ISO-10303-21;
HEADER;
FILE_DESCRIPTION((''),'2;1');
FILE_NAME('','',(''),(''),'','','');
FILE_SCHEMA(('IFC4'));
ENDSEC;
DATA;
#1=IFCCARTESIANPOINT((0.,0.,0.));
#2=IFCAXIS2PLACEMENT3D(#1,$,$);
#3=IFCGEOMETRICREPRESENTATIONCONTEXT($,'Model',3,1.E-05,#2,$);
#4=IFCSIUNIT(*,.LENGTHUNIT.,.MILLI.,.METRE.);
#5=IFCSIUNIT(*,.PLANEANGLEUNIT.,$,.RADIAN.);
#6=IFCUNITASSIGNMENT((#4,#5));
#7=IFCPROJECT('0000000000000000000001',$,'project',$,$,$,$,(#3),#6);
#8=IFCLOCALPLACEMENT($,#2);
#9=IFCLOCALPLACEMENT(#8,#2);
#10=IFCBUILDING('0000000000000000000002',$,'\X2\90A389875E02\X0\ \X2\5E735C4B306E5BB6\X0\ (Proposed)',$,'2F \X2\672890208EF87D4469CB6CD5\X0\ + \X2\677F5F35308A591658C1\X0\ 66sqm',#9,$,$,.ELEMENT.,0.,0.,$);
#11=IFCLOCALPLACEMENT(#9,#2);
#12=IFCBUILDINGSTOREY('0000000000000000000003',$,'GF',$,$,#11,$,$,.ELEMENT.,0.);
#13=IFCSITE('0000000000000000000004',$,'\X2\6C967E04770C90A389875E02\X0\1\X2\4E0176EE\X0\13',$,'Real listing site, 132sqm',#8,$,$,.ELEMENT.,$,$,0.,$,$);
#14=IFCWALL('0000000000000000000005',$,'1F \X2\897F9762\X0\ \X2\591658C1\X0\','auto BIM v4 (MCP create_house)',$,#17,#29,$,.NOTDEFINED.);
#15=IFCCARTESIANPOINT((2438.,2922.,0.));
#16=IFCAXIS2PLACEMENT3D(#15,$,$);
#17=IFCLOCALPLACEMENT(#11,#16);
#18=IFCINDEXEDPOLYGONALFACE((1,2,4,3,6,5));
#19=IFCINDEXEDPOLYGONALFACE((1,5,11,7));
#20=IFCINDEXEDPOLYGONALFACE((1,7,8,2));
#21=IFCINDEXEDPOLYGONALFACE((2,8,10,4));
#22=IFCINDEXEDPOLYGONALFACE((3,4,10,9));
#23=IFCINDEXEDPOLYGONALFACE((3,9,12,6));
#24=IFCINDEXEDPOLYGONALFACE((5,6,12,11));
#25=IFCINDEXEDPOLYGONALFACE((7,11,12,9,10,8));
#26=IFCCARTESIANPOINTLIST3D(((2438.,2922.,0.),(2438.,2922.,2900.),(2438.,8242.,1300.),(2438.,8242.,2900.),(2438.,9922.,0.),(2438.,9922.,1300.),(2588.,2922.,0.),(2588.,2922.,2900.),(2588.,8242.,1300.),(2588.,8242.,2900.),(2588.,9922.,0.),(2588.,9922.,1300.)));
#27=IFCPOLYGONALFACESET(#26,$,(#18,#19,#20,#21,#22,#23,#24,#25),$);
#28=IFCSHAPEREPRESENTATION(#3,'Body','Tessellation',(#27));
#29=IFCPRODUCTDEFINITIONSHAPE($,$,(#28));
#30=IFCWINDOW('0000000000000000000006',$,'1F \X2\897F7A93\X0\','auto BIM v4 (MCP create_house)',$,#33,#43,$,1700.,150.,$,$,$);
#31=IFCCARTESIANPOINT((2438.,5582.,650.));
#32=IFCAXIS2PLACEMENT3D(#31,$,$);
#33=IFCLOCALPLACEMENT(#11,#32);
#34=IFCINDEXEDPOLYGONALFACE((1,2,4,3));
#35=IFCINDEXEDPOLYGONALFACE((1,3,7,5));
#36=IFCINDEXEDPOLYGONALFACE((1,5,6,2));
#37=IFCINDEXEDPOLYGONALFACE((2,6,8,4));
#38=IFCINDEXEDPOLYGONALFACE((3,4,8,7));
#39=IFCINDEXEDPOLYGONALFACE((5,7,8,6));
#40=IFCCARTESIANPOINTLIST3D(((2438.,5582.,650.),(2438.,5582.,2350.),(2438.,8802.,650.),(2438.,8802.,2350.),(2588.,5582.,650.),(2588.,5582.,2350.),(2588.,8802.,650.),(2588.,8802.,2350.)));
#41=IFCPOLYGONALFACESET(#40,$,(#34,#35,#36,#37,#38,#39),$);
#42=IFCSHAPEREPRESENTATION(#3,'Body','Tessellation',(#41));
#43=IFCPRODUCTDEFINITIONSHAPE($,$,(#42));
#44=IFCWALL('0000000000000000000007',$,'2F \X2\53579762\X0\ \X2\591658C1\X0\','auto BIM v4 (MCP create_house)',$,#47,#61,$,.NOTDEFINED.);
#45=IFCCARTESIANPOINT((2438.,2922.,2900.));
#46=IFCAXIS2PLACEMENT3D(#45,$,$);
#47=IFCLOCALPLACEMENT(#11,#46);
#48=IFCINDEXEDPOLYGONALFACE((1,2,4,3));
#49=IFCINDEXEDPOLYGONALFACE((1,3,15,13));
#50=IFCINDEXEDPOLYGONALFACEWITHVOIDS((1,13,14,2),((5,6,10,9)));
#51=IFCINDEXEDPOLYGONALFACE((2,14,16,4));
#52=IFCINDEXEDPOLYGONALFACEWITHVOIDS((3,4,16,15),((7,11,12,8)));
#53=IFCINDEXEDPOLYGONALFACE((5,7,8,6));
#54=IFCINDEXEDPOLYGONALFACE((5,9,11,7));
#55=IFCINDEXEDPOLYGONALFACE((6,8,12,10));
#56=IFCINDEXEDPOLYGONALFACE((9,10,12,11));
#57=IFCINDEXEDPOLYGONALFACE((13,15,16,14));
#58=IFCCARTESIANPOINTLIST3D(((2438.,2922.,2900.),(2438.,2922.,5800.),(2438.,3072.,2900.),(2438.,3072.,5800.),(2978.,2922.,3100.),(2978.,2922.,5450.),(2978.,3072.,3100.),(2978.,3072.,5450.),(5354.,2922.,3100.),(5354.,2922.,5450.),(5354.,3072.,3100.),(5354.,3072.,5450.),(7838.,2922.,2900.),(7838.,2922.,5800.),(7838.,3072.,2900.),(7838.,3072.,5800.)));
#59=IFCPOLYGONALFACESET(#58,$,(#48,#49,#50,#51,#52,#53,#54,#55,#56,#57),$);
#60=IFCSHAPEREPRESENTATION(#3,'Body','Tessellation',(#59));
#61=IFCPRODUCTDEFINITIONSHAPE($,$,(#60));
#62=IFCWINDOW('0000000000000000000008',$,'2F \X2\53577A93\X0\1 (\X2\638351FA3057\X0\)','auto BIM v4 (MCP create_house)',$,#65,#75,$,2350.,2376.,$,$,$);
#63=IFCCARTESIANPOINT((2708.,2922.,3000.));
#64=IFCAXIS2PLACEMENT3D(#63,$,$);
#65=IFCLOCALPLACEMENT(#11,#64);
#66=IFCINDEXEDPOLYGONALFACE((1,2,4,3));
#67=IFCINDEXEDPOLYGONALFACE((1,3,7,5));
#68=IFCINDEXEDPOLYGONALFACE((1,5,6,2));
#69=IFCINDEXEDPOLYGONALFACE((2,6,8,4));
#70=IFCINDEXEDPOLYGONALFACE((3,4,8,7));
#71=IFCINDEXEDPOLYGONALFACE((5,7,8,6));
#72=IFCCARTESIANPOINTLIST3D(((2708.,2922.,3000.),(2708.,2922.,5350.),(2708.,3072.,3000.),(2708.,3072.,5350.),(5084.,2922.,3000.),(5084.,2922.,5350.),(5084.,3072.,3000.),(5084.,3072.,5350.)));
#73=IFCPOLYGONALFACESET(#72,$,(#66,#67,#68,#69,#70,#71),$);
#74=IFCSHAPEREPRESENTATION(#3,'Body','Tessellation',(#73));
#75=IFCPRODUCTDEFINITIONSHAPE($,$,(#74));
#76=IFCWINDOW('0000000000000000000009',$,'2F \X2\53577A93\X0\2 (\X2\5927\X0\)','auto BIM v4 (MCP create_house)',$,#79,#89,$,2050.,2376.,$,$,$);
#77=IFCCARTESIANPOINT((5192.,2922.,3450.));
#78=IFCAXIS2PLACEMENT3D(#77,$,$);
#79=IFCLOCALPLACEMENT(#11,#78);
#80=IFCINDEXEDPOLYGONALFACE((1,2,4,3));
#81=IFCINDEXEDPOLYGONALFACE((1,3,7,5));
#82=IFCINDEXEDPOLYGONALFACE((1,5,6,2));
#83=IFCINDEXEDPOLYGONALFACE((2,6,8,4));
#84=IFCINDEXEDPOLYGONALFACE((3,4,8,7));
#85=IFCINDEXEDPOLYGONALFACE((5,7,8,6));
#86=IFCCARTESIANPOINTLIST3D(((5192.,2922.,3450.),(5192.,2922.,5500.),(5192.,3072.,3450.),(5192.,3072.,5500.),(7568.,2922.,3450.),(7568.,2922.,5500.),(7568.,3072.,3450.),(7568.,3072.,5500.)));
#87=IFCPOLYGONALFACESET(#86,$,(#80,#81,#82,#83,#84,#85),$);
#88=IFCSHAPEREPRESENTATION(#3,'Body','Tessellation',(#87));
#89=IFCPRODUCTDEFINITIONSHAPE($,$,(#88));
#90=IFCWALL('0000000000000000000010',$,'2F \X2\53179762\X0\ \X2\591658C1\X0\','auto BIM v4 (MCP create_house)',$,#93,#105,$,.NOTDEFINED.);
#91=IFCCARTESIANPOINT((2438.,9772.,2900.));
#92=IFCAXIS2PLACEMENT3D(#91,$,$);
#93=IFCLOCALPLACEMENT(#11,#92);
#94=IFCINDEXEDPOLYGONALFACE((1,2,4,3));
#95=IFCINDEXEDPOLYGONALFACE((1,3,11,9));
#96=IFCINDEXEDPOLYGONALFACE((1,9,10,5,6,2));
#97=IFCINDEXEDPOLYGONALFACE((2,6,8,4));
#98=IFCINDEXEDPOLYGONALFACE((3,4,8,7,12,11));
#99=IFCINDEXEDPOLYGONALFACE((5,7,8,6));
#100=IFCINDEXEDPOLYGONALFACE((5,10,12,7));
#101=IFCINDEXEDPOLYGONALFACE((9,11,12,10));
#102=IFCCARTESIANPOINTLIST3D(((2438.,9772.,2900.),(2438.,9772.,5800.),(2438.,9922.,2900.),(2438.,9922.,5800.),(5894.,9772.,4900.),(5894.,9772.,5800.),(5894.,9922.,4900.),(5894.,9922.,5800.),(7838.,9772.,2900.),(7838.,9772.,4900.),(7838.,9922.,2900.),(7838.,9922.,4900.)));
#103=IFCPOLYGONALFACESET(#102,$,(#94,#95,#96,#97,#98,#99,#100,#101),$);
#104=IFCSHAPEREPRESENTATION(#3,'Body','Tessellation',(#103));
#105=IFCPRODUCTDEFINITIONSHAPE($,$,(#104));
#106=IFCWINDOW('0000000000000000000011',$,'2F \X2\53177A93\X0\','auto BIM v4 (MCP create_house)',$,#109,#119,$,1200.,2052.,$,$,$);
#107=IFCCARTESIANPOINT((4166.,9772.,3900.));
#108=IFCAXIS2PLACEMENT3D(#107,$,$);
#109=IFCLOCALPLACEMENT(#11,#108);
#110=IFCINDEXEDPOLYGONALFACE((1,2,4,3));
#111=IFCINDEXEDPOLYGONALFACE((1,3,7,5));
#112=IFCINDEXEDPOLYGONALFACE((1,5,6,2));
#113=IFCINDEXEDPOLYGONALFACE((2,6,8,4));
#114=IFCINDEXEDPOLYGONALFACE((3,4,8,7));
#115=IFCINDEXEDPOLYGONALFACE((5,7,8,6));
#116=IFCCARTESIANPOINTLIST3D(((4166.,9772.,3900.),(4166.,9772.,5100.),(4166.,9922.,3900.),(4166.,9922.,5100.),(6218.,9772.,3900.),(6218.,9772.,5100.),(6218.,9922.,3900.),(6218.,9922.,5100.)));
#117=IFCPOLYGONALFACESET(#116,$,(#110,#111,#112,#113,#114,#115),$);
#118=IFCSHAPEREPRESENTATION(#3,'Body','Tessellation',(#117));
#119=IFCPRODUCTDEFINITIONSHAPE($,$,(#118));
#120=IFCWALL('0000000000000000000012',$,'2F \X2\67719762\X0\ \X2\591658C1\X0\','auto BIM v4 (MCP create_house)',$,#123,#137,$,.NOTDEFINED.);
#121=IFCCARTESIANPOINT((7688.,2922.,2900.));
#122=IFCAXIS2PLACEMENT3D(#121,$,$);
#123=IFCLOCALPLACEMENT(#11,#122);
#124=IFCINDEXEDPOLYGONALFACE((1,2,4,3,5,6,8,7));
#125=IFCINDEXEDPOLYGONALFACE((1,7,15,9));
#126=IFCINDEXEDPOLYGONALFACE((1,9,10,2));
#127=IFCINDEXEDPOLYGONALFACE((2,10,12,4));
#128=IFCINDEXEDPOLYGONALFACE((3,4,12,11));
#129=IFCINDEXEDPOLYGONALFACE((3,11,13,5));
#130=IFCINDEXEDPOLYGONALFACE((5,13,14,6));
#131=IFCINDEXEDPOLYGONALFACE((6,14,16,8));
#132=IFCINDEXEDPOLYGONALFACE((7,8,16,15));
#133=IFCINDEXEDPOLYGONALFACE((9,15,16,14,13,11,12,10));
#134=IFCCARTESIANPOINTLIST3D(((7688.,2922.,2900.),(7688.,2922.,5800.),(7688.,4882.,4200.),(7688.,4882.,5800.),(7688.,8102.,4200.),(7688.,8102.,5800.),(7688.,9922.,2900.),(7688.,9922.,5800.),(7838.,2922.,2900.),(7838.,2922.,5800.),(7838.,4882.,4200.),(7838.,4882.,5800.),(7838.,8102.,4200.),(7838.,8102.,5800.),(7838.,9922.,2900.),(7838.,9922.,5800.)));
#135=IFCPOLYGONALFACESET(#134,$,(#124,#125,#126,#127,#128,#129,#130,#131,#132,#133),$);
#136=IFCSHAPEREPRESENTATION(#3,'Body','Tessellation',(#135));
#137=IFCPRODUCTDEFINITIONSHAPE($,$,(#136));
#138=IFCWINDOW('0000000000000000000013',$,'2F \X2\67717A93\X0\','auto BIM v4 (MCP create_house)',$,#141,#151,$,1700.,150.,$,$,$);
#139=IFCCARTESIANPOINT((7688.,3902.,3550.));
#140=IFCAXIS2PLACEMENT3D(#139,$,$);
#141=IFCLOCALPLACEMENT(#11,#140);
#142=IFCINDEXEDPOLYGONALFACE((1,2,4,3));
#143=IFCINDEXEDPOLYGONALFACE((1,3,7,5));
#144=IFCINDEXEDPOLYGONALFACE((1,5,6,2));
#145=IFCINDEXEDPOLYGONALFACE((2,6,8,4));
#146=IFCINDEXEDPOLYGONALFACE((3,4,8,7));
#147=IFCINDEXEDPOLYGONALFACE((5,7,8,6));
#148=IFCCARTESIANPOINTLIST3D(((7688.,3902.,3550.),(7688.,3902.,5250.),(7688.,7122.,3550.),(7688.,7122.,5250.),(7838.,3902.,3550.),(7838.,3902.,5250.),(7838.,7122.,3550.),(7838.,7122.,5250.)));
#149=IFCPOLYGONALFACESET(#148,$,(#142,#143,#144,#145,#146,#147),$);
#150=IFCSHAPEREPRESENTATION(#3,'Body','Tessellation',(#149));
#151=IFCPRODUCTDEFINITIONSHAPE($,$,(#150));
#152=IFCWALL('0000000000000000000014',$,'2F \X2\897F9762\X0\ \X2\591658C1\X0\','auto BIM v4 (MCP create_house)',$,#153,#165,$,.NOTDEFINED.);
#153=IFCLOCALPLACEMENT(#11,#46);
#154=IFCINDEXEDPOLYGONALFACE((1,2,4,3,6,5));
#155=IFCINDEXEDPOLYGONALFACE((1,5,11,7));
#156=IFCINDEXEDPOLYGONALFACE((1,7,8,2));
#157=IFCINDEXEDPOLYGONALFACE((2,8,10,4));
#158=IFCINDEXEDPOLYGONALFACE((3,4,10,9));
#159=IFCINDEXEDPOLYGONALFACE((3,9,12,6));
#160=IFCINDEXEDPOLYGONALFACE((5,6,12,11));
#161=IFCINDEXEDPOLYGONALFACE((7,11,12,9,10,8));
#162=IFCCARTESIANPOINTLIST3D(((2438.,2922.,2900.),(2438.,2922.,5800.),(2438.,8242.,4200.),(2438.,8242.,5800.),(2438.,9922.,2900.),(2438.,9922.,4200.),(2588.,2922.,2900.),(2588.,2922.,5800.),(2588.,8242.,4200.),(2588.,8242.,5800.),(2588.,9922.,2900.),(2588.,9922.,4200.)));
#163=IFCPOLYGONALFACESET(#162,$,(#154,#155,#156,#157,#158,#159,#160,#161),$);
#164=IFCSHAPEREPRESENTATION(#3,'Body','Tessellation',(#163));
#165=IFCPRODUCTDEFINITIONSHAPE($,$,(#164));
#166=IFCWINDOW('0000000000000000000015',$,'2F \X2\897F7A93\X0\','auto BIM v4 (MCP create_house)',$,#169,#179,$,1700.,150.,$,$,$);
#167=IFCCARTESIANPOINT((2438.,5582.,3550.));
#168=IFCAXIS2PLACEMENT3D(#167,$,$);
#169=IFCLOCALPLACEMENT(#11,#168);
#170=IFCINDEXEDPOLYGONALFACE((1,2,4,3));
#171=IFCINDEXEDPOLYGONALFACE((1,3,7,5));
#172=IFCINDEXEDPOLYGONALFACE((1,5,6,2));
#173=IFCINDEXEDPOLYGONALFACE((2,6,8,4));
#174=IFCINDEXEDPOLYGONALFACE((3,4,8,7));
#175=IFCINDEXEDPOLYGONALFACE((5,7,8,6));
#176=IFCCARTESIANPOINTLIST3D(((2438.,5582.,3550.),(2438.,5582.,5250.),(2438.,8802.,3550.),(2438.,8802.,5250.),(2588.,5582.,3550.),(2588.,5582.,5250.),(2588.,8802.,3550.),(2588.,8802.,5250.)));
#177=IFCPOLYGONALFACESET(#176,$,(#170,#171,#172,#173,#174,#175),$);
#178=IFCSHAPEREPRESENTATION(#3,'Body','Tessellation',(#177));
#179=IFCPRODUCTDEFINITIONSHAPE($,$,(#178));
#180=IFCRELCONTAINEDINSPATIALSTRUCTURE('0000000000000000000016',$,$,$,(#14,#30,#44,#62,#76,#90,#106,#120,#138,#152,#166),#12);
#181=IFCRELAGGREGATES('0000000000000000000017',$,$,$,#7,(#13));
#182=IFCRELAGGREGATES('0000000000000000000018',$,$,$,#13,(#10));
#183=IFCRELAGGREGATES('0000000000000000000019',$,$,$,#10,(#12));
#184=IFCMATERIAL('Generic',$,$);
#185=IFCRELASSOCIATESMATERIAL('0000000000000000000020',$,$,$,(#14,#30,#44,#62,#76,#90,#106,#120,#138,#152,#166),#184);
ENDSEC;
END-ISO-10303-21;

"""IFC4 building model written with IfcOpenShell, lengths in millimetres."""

from ifc_helpers import new_model, si_unit, frame, frame_2d, origin, place, context, project, spatial, rectangle, extrude, material, element, fill, save


model = new_model("IFC4")

# Units and contexts
model_context = context("Model", 3, precision=1e-05, world=origin())
ifc_project = project(units=[si_unit("LENGTHUNIT", "METRE", prefix="MILLI"), si_unit("PLANEANGLEUNIT", "RADIAN")], contexts=[model_context])

# Site, building, storey
site_placement = place(None, origin())
site = spatial("IfcSite", under=ifc_project, at=site_placement, Name="沖縄県那覇市1丁目13", ObjectType="Real listing site, 132sqm", CompositionType="ELEMENT", RefElevation=0.0)
building_placement = place(site_placement, origin())
building = spatial("IfcBuilding", under=site, at=building_placement, Name="那覇市 平屋の家 (Proposed)", ObjectType="2F 木造軸組構法 + 板張り外壁 66sqm", CompositionType="ELEMENT", ElevationOfRefHeight=0.0, ElevationOfTerrain=0.0)
storey_placement = place(building_placement, origin())
storey = spatial("IfcBuildingStorey", under=building, at=storey_placement, Name="GF", CompositionType="ELEMENT", Elevation=0.0)

# Shared definitions
ifc_material = material(Name="Generic")

# Wall, opening, window
wall_1_placement = place(storey_placement, frame((2438.0, 2922.0, 0.0)))
wall_1 = element("IfcWall", 1, at=wall_1_placement, inside=storey, material=ifc_material, Name="1F 西面 外壁", Description="auto BIM v4 (MCP create_house)", PredefinedType="NOTDEFINED", context=model_context, shape_type="SweptSolid", body=[
    extrude(rectangle(XDim=150.0, YDim=7000.0, at=frame_2d((75.0, 3500.0))), frame((2438.0, 2922.0, 0.0)), (0.0, 0.0, 1.0), 2900.0),
])
opening_1_placement = place(storey_placement, frame((2438.0, 5582.0, 650.0)))
opening_1 = element("IfcOpeningElement", 2, at=opening_1_placement, cuts=wall_1, PredefinedType="NOTDEFINED", context=model_context, shape_type="SweptSolid", body=[
    extrude(rectangle(XDim=150.0, YDim=3220.0, at=frame_2d((75.0, 1610.0))), frame((2438.0, 5582.0, 650.0)), (0.0, 0.0, 1.0), 1700.0),
])
window_1_placement = place(storey_placement, frame((2438.0, 5582.0, 650.0)))
window_1 = element("IfcWindow", 3, at=window_1_placement, inside=storey, material=ifc_material, Name="1F 西窓", Description="auto BIM v4 (MCP create_house)", OverallHeight=1700.0, OverallWidth=150.0, context=model_context, shape_type="SweptSolid", body=[
    extrude(rectangle(XDim=150.0, YDim=3220.0, at=frame_2d((75.0, 1610.0))), frame((2438.0, 5582.0, 650.0)), (0.0, 0.0, 1.0), 1700.0),
])
fill(opening_1, window_1)

# Wall, openings, windows
wall_2_placement = place(storey_placement, frame((2438.0, 2922.0, 2900.0)))
wall_2 = element("IfcWall", 4, at=wall_2_placement, inside=storey, material=ifc_material, Name="2F 南面 外壁", Description="auto BIM v4 (MCP create_house)", PredefinedType="NOTDEFINED", context=model_context, shape_type="SweptSolid", body=[
    extrude(rectangle(XDim=5400.0, YDim=150.0, at=frame_2d((2700.0, 75.0))), frame((2438.0, 2922.0, 2900.0)), (0.0, 0.0, 1.0), 2900.0),
])
opening_2_placement = place(storey_placement, frame((2708.0, 2922.0, 3000.0)))
opening_2 = element("IfcOpeningElement", 5, at=opening_2_placement, cuts=wall_2, PredefinedType="NOTDEFINED", context=model_context, shape_type="SweptSolid", body=[
    extrude(rectangle(XDim=2376.0, YDim=150.0, at=frame_2d((1188.0, 75.0))), frame((2708.0, 2922.0, 3000.0)), (0.0, 0.0, 1.0), 2350.0),
])
opening_3_placement = place(storey_placement, frame((5192.0, 2922.0, 3450.0)))
opening_3 = element("IfcOpeningElement", 6, at=opening_3_placement, cuts=wall_2, PredefinedType="NOTDEFINED", context=model_context, shape_type="SweptSolid", body=[
    extrude(rectangle(XDim=2376.0, YDim=150.0, at=frame_2d((1188.0, 75.0))), frame((5192.0, 2922.0, 3450.0)), (0.0, 0.0, 1.0), 2050.0),
])
window_2_placement = place(storey_placement, frame((2708.0, 2922.0, 3000.0)))
window_2 = element("IfcWindow", 7, at=window_2_placement, inside=storey, material=ifc_material, Name="2F 南窓1 (掃出し)", Description="auto BIM v4 (MCP create_house)", OverallHeight=2350.0, OverallWidth=2376.0, context=model_context, shape_type="SweptSolid", body=[
    extrude(rectangle(XDim=2376.0, YDim=150.0, at=frame_2d((1188.0, 75.0))), frame((2708.0, 2922.0, 3000.0)), (0.0, 0.0, 1.0), 2350.0),
])
fill(opening_2, window_2)
window_3_placement = place(storey_placement, frame((5192.0, 2922.0, 3450.0)))
window_3 = element("IfcWindow", 8, at=window_3_placement, inside=storey, material=ifc_material, Name="2F 南窓2 (大)", Description="auto BIM v4 (MCP create_house)", OverallHeight=2050.0, OverallWidth=2376.0, context=model_context, shape_type="SweptSolid", body=[
    extrude(rectangle(XDim=2376.0, YDim=150.0, at=frame_2d((1188.0, 75.0))), frame((5192.0, 2922.0, 3450.0)), (0.0, 0.0, 1.0), 2050.0),
])
fill(opening_3, window_3)

# Walls, openings, windows
wall_3_placement = place(storey_placement, frame((2438.0, 9772.0, 2900.0)))
wall_3 = element("IfcWall", 9, at=wall_3_placement, inside=storey, material=ifc_material, Name="2F 北面 外壁", Description="auto BIM v4 (MCP create_house)", PredefinedType="NOTDEFINED", context=model_context, shape_type="SweptSolid", body=[
    extrude(rectangle(XDim=5400.0, YDim=150.0, at=frame_2d((2700.0, 75.0))), frame((2438.0, 9772.0, 2900.0)), (0.0, 0.0, 1.0), 2900.0),
])
opening_4_placement = place(storey_placement, frame((4166.0, 9772.0, 3900.0)))
opening_4 = element("IfcOpeningElement", 10, at=opening_4_placement, cuts=wall_3, PredefinedType="NOTDEFINED", context=model_context, shape_type="SweptSolid", body=[
    extrude(rectangle(XDim=2052.0, YDim=150.0, at=frame_2d((1026.0, 75.0))), frame((4166.0, 9772.0, 3900.0)), (0.0, 0.0, 1.0), 1200.0),
])
window_4_placement = place(storey_placement, frame((4166.0, 9772.0, 3900.0)))
window_4 = element("IfcWindow", 11, at=window_4_placement, inside=storey, material=ifc_material, Name="2F 北窓", Description="auto BIM v4 (MCP create_house)", OverallHeight=1200.0, OverallWidth=2052.0, context=model_context, shape_type="SweptSolid", body=[
    extrude(rectangle(XDim=2052.0, YDim=150.0, at=frame_2d((1026.0, 75.0))), frame((4166.0, 9772.0, 3900.0)), (0.0, 0.0, 1.0), 1200.0),
])
fill(opening_4, window_4)
wall_4_placement = place(storey_placement, frame((7688.0, 2922.0, 2900.0)))
wall_4 = element("IfcWall", 12, at=wall_4_placement, inside=storey, material=ifc_material, Name="2F 東面 外壁", Description="auto BIM v4 (MCP create_house)", PredefinedType="NOTDEFINED", context=model_context, shape_type="SweptSolid", body=[
    extrude(rectangle(XDim=150.0, YDim=7000.0, at=frame_2d((75.0, 3500.0))), frame((7688.0, 2922.0, 2900.0)), (0.0, 0.0, 1.0), 2900.0),
])
opening_5_placement = place(storey_placement, frame((7688.0, 3902.0, 3550.0)))
opening_5 = element("IfcOpeningElement", 13, at=opening_5_placement, cuts=wall_4, PredefinedType="NOTDEFINED", context=model_context, shape_type="SweptSolid", body=[
    extrude(rectangle(XDim=150.0, YDim=3220.0, at=frame_2d((75.0, 1610.0))), frame((7688.0, 3902.0, 3550.0)), (0.0, 0.0, 1.0), 1700.0),
])
window_5_placement = place(storey_placement, frame((7688.0, 3902.0, 3550.0)))
window_5 = element("IfcWindow", 14, at=window_5_placement, inside=storey, material=ifc_material, Name="2F 東窓", Description="auto BIM v4 (MCP create_house)", OverallHeight=1700.0, OverallWidth=150.0, context=model_context, shape_type="SweptSolid", body=[
    extrude(rectangle(XDim=150.0, YDim=3220.0, at=frame_2d((75.0, 1610.0))), frame((7688.0, 3902.0, 3550.0)), (0.0, 0.0, 1.0), 1700.0),
])
fill(opening_5, window_5)
wall_5_placement = place(storey_placement, frame((2438.0, 2922.0, 2900.0)))
wall_5 = element("IfcWall", 15, at=wall_5_placement, inside=storey, material=ifc_material, Name="2F 西面 外壁", Description="auto BIM v4 (MCP create_house)", PredefinedType="NOTDEFINED", context=model_context, shape_type="SweptSolid", body=[
    extrude(rectangle(XDim=150.0, YDim=7000.0, at=frame_2d((75.0, 3500.0))), frame((2438.0, 2922.0, 2900.0)), (0.0, 0.0, 1.0), 2900.0),
])
opening_6_placement = place(storey_placement, frame((2438.0, 5582.0, 3550.0)))
opening_6 = element("IfcOpeningElement", 16, at=opening_6_placement, cuts=wall_5, PredefinedType="NOTDEFINED", context=model_context, shape_type="SweptSolid", body=[
    extrude(rectangle(XDim=150.0, YDim=3220.0, at=frame_2d((75.0, 1610.0))), frame((2438.0, 5582.0, 3550.0)), (0.0, 0.0, 1.0), 1700.0),
])
window_6_placement = place(storey_placement, frame((2438.0, 5582.0, 3550.0)))
window_6 = element("IfcWindow", 17, at=window_6_placement, inside=storey, material=ifc_material, Name="2F 西窓", Description="auto BIM v4 (MCP create_house)", OverallHeight=1700.0, OverallWidth=150.0, context=model_context, shape_type="SweptSolid", body=[
    extrude(rectangle(XDim=150.0, YDim=3220.0, at=frame_2d((75.0, 1610.0))), frame((2438.0, 5582.0, 3550.0)), (0.0, 0.0, 1.0), 1700.0),
])
fill(opening_6, window_6)

save(model, "model.ifc")
